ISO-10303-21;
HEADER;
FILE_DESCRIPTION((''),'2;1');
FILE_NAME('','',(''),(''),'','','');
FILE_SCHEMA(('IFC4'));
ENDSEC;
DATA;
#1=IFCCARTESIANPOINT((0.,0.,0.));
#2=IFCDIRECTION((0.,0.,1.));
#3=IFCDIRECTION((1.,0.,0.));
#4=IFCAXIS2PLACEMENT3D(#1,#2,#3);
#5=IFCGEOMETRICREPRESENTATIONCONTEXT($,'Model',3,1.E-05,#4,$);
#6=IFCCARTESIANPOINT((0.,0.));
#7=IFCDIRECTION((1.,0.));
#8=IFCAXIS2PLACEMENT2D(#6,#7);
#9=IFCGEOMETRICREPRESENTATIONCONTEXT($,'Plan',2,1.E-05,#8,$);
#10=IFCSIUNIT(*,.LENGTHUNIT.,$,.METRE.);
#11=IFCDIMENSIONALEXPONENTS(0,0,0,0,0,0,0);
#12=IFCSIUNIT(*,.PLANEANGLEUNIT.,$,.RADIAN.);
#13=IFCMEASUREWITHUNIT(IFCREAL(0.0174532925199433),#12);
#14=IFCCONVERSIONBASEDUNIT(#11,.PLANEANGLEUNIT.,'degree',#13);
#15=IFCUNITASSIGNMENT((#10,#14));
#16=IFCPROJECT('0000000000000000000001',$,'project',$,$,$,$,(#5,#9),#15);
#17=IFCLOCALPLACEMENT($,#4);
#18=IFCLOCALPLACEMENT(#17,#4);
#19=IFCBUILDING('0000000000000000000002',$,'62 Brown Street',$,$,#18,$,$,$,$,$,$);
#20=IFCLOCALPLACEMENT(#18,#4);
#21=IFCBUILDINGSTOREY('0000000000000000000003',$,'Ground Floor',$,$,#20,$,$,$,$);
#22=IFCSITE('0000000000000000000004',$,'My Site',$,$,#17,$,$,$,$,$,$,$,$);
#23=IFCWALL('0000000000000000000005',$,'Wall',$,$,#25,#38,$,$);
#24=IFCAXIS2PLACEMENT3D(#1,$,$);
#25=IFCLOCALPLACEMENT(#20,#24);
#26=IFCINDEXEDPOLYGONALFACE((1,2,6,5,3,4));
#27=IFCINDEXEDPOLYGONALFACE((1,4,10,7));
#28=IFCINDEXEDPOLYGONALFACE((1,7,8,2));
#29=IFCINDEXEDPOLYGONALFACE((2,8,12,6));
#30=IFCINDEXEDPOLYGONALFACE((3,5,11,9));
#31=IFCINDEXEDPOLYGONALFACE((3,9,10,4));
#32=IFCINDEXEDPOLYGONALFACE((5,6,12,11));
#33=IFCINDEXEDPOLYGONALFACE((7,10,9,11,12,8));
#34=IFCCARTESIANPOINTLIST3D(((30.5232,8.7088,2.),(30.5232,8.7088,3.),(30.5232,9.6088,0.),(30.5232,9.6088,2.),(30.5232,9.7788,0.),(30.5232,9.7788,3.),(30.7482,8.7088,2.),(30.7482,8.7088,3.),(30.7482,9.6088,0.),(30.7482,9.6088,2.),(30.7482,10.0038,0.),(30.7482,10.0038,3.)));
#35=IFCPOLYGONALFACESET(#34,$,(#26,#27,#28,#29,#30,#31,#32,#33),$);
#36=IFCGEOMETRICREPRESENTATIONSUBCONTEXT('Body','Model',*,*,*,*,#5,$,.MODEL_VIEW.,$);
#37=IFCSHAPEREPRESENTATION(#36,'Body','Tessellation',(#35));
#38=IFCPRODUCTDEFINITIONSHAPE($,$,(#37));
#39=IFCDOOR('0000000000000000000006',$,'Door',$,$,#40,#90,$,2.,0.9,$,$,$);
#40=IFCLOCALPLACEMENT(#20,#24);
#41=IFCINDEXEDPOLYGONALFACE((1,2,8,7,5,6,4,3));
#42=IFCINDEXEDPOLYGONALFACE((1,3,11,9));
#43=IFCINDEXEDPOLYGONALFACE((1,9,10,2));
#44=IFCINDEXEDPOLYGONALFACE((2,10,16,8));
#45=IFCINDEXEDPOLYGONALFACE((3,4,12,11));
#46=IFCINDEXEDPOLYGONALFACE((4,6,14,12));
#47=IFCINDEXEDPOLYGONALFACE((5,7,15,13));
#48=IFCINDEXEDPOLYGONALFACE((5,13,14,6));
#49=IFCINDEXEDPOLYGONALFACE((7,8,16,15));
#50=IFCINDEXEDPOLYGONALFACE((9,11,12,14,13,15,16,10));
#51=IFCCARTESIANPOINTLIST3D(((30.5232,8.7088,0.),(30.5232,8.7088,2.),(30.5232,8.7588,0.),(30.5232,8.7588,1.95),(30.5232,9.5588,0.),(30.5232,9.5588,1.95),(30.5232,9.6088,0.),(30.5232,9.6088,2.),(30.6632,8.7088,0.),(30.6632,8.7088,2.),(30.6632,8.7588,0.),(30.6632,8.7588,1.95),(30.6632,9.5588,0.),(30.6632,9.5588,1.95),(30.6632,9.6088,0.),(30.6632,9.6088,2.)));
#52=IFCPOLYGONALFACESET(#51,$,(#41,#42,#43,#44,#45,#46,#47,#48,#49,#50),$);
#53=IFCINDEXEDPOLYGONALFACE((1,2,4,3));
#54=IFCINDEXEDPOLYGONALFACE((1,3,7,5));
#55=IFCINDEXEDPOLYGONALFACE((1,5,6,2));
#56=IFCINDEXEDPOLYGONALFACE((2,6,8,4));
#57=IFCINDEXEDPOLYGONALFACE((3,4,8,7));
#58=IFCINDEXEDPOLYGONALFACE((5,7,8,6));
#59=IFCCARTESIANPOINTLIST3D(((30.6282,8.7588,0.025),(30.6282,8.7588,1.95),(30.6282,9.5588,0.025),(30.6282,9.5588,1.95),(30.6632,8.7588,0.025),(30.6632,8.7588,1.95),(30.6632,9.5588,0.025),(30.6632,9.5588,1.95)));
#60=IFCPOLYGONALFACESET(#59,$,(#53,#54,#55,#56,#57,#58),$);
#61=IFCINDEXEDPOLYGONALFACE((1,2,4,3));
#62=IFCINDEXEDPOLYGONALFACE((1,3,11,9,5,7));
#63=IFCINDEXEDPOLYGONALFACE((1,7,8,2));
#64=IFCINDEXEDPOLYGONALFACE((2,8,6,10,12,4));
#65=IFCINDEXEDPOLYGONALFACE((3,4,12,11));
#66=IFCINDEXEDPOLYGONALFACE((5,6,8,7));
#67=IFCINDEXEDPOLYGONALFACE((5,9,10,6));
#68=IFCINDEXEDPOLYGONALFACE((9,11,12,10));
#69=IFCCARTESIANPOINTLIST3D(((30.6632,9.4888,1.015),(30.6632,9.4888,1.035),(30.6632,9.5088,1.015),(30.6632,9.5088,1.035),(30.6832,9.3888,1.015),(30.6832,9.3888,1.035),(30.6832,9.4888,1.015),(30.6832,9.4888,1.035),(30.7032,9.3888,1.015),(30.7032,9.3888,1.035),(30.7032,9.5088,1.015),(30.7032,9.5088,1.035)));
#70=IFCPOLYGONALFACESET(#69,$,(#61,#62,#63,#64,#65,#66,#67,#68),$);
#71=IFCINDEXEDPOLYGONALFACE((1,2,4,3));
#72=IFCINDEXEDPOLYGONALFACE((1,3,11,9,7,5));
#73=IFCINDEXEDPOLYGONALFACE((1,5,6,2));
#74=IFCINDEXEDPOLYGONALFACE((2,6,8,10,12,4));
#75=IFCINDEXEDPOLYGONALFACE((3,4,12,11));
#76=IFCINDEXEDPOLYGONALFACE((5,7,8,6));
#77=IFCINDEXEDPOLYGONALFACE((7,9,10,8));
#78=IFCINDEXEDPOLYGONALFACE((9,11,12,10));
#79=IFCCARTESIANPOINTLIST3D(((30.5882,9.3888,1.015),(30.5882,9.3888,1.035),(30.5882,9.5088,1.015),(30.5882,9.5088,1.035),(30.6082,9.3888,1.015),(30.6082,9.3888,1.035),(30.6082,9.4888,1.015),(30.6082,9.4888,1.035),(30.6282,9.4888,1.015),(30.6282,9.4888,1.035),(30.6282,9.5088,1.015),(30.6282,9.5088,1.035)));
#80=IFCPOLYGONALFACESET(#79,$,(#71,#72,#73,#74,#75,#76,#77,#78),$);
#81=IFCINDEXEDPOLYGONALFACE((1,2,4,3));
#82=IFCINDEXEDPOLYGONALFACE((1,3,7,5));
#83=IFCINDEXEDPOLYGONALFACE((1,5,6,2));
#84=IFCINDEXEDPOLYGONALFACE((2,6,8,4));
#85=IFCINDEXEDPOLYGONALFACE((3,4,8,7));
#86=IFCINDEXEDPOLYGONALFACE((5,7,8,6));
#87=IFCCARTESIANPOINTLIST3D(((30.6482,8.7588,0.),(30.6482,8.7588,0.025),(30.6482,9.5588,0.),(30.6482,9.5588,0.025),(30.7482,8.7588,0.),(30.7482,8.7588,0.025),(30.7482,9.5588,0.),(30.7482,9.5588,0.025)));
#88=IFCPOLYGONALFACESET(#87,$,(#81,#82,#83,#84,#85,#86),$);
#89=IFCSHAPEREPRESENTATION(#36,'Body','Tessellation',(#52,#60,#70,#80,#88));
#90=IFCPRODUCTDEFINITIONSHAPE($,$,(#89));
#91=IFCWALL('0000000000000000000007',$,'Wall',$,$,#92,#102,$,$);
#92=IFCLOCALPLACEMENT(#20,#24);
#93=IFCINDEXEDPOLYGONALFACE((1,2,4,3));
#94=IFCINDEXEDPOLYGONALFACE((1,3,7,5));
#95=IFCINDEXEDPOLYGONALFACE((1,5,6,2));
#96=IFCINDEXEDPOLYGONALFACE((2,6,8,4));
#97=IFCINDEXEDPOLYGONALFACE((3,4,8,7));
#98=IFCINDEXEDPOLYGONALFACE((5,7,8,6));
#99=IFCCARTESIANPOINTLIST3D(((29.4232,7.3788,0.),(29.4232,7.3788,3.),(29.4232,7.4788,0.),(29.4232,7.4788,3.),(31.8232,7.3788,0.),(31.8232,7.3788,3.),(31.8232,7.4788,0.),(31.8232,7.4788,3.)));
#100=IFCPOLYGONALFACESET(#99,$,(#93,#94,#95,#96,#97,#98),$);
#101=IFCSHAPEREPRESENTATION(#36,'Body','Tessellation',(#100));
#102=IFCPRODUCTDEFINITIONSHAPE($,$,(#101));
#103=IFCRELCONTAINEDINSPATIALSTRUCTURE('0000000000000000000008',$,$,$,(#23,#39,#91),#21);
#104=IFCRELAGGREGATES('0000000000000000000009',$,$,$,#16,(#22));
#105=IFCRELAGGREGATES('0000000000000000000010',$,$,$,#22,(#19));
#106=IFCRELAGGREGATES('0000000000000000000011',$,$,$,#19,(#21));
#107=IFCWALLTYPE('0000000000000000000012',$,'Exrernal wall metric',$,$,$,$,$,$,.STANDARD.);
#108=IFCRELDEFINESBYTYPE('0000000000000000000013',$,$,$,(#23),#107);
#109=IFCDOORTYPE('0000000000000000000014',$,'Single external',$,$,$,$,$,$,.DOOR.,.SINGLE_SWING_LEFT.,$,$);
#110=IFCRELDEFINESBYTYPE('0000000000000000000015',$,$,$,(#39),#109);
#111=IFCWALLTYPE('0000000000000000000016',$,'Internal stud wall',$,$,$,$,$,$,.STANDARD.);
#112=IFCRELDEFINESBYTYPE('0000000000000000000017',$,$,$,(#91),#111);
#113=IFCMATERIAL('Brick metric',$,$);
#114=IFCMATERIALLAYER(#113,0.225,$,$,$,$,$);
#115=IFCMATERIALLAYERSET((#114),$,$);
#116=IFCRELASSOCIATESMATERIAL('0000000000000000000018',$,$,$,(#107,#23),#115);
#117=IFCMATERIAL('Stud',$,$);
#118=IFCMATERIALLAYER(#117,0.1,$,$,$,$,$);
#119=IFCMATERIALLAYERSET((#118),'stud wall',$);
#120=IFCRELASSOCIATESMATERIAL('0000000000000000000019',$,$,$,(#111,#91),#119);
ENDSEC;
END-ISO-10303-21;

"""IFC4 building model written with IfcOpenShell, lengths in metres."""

from ifc_helpers import new_model, entity, si_unit, converted_unit, frame, origin_with_axes, origin_2d_with_axis, place, context, subcontext, project, spatial, line, indexed_curve, outline, extrude, clip, halfspace, shape, source, transform, mapped, material, layer, layer_set, layer_usage, type_object, type_shapes, element, fill, save


model = new_model("IFC4")

# Units and contexts
model_context = context("Model", 3, precision=1e-05, world=origin_with_axes())
plan_context = context("Plan", 2, precision=1e-05, world=origin_2d_with_axis())
body_context_1 = subcontext(model_context, "Body", "Model", "MODEL_VIEW")
body_context_2 = subcontext(plan_context, "Body", "Plan", "PLAN_VIEW")
ifc_project = project(units=[si_unit("LENGTHUNIT", "METRE"), converted_unit("PLANEANGLEUNIT", "degree", entity("IfcReal", 0.0174532925199433), si_unit("PLANEANGLEUNIT", "RADIAN"), dimensions=[0, 0, 0, 0, 0, 0, 0])], contexts=[model_context, plan_context])

# Site, building, storey
site_placement = place(None, origin_with_axes())
site = spatial("IfcSite", under=ifc_project, at=site_placement, Name="My Site")
building_placement = place(site_placement, origin_with_axes())
building = spatial("IfcBuilding", under=site, at=building_placement, Name="62 Brown Street")
storey_placement = place(building_placement, origin_with_axes())
storey = spatial("IfcBuildingStorey", under=building, at=storey_placement, Name="Ground Floor")

# Shared definitions
ifc_material_1 = material(Name="Brick metric")
ifc_layer_1 = layer(ifc_material_1, 0.225)
ifc_layer_set_1 = layer_set([ifc_layer_1])
wall_type_1 = type_object("IfcWallType", Name="Exrernal wall metric", PredefinedType="STANDARD", material=ifc_layer_set_1)

# Wall, opening, door
ifc_layer_usage_1 = layer_usage(ifc_layer_set_1, "AXIS2", "POSITIVE", 0.0)
wall_1_placement = place(storey_placement, frame((30.7482, 8.7088, 0.0), z_axis=(0.0, 0.0, 1.0), x_axis=(0.0, 1.0, 0.0)))
wall_1 = element("IfcWall", 1, at=wall_1_placement, inside=storey, type_object=wall_type_1, material=ifc_layer_usage_1, Name="Wall", context=body_context_1, shape_type="Clipping", body=[
    clip(extrude(outline(indexed_curve([(0.0, 0.0), (0.0, 0.225), (1.295, 0.225), (1.295, 0.0), (0.0, 0.0)], self_intersect=False)), origin_with_axes(), (0.0, 0.0, 1.0), 3.0), halfspace(frame((1.295, 0.0, 0.0), z_axis=(0.675001, 0.675001, 0.0), x_axis=(-0.225, 0.225, 0.0)), False)),
])
shared_shape_1 = source(origin_with_axes(), body_context_1, "Body", "SweptSolid", [
    extrude(outline(indexed_curve([(0.0, 0.0), (0.9, 0.0), (0.9, 2.0), (0.0, 2.0)], segments=[line(1, 2, 3, 4, 1)])), frame((0.0, -0.6, 0.0), z_axis=(0.0, -1.0, 0.0), x_axis=(1.0, 0.0, 0.0)), (0.0, 0.0, -1.0), 1.2),
])
opening_1_placement = place(wall_1_placement, frame((0.0, 0.0, 0.0), z_axis=(0.0, 0.0, 1.0), x_axis=(1.0, 0.0, 0.0)))
opening_1 = element("IfcOpeningElement", 2, at=opening_1_placement, cuts=wall_1, PredefinedType="OPENING", context=body_context_1, shape_type="MappedRepresentation", body=[
    mapped(shared_shape_1, transform((0.0, 0.0, 0.0), x_axis=(1.0, 0.0, 0.0), y_axis=(0.0, 1.0, 0.0), z_axis=(0.0, 0.0, 1.0), scale=1.0)),
])
door_type_1 = type_object("IfcDoorType", Name="Single external", OperationType="SINGLE_SWING_LEFT", PredefinedType="DOOR")
shared_shape_2 = source(origin_with_axes(), body_context_1, "Body", "SweptSolid", [
    extrude(outline(indexed_curve([(0.0, 0.0), (0.0, 2.0), (0.9, 2.0), (0.9, 0.0), (0.85, 0.0), (0.85, 1.95), (0.05, 1.95), (0.05, 0.0)], segments=[line(1, 2, 3, 4, 5, 6, 7, 8, 1)])), frame((0.0, 0.085, 0.0), z_axis=(0.0, -1.0, 0.0), x_axis=(1.0, 0.0, 0.0)), (0.0, 0.0, -1.0), 0.14),
    extrude(outline(indexed_curve([(0.0, 0.0), (0.8, 0.0), (0.8, 0.035), (0.0, 0.035)], segments=[line(1, 2, 3, 4, 1)])), frame((0.05, 0.085, 0.025), z_axis=(0.0, 0.0, 1.0), x_axis=(1.0, 0.0, 0.0)), (0.0, 0.0, 1.0), 1.925),
    extrude(outline(indexed_curve([(0.0, 0.0), (0.0, -0.04), (-0.12, -0.04), (-0.12, -0.02), (-0.02, -0.02), (-0.02, 0.0)], segments=[line(1, 2, 3, 4, 5, 6, 1)])), frame((0.8, 0.085, 1.015), z_axis=(0.0, 0.0, 1.0), x_axis=(1.0, 0.0, 0.0)), (0.0, 0.0, 1.0), 0.02),
    extrude(outline(indexed_curve([(0.0, 0.0), (0.0, 0.04), (-0.12, 0.04), (-0.12, 0.02), (-0.02, 0.02), (-0.02, 0.0)], segments=[line(1, 2, 3, 4, 5, 6, 1)])), frame((0.8, 0.12, 1.015), z_axis=(0.0, 0.0, 1.0), x_axis=(1.0, 0.0, 0.0)), (0.0, 0.0, 1.0), 0.02),
    extrude(outline(indexed_curve([(0.0, 0.0), (0.8, 0.0), (0.8, 0.1), (0.0, 0.1)], segments=[line(1, 2, 3, 4, 1)])), frame((0.05, 0.0, 0.0), z_axis=(0.0, 0.0, 1.0), x_axis=(1.0, 0.0, 0.0)), (0.0, 0.0, 1.0), 0.025),
])
shared_shape_3 = source(origin_with_axes(), body_context_2, "Body", "Curve2D", [
    entity("IfcIndexedPolyCurve", entity("IfcCartesianPointList2D", [[0.0, 0.085], [0.05, 0.085], [0.05, 0.225], [0.0, 0.225]]), [entity("IfcLineIndex", [1, 2, 3, 4, 1])]),
    entity("IfcIndexedPolyCurve", entity("IfcCartesianPointList2D", [[0.9, 0.085], [0.85, 0.085], [0.85, 0.225], [0.9, 0.225]]), [entity("IfcLineIndex", [1, 2, 3, 4, 1])]),
    entity("IfcTrimmedCurve", entity("IfcEllipse", entity("IfcAxis2Placement2D", entity("IfcCartesianPoint", [0.085, 0.225]), entity("IfcDirection", [1.0, 0.0])), 0.765, 0.8), [entity("IfcCartesianPoint", [0.85, 0.225])], [entity("IfcCartesianPoint", [0.085, 1.025])], True, "CARTESIAN"),
    entity("IfcIndexedPolyCurve", entity("IfcCartesianPointList2D", [[0.05, 0.225], [0.085, 0.225], [0.085, 1.025], [0.05, 1.025]]), [entity("IfcLineIndex", [1, 2, 3, 4, 1])]),
])
type_shapes(door_type_1, [shared_shape_2, shared_shape_3])
door_1_placement = place(opening_1_placement, origin_with_axes())
door_1 = element("IfcDoor", 3, at=door_1_placement, inside=storey, type_object=door_type_1, Name="Door", OverallHeight=2.0, OverallWidth=0.9, shapes=[
    shape(body_context_1, "Body", "MappedRepresentation", [mapped(shared_shape_2, transform((0.0, 0.0, 0.0), x_axis=(1.0, 0.0, 0.0), y_axis=(0.0, 1.0, 0.0), z_axis=(0.0, 0.0, 1.0), scale=1.0))]),
    shape(body_context_2, "Body", "MappedRepresentation", [mapped(shared_shape_3, transform((0.0, 0.0, 0.0), x_axis=(1.0, 0.0, 0.0), y_axis=(0.0, 1.0, 0.0), z_axis=(0.0, 0.0, 1.0), scale=1.0))]),
])
fill(opening_1, door_1)

# Wall
ifc_material_2 = material(Name="Stud")
ifc_layer_2 = layer(ifc_material_2, 0.1)
ifc_layer_set_2 = layer_set([ifc_layer_2], Name="stud wall")
ifc_layer_usage_2 = layer_usage(ifc_layer_set_2, "AXIS2", "POSITIVE", 0.0)
wall_type_2 = type_object("IfcWallType", Name="Internal stud wall", PredefinedType="STANDARD", material=ifc_layer_set_2)
wall_2_placement = place(storey_placement, frame((29.4232, 7.3788, 0.0), z_axis=(0.0, 0.0, 1.0), x_axis=(1.0, 0.0, 0.0)))
element("IfcWall", 4, at=wall_2_placement, inside=storey, type_object=wall_type_2, material=ifc_layer_usage_2, Name="Wall", context=body_context_1, shape_type="SweptSolid", body=[
    extrude(outline(indexed_curve([(0.0, 0.0), (0.0, 0.1), (2.4, 0.1), (2.4, 0.0), (0.0, 0.0)], self_intersect=False)), origin_with_axes(), (0.0, 0.0, 1.0), 3.0),
])

save(model, "model.ifc")
